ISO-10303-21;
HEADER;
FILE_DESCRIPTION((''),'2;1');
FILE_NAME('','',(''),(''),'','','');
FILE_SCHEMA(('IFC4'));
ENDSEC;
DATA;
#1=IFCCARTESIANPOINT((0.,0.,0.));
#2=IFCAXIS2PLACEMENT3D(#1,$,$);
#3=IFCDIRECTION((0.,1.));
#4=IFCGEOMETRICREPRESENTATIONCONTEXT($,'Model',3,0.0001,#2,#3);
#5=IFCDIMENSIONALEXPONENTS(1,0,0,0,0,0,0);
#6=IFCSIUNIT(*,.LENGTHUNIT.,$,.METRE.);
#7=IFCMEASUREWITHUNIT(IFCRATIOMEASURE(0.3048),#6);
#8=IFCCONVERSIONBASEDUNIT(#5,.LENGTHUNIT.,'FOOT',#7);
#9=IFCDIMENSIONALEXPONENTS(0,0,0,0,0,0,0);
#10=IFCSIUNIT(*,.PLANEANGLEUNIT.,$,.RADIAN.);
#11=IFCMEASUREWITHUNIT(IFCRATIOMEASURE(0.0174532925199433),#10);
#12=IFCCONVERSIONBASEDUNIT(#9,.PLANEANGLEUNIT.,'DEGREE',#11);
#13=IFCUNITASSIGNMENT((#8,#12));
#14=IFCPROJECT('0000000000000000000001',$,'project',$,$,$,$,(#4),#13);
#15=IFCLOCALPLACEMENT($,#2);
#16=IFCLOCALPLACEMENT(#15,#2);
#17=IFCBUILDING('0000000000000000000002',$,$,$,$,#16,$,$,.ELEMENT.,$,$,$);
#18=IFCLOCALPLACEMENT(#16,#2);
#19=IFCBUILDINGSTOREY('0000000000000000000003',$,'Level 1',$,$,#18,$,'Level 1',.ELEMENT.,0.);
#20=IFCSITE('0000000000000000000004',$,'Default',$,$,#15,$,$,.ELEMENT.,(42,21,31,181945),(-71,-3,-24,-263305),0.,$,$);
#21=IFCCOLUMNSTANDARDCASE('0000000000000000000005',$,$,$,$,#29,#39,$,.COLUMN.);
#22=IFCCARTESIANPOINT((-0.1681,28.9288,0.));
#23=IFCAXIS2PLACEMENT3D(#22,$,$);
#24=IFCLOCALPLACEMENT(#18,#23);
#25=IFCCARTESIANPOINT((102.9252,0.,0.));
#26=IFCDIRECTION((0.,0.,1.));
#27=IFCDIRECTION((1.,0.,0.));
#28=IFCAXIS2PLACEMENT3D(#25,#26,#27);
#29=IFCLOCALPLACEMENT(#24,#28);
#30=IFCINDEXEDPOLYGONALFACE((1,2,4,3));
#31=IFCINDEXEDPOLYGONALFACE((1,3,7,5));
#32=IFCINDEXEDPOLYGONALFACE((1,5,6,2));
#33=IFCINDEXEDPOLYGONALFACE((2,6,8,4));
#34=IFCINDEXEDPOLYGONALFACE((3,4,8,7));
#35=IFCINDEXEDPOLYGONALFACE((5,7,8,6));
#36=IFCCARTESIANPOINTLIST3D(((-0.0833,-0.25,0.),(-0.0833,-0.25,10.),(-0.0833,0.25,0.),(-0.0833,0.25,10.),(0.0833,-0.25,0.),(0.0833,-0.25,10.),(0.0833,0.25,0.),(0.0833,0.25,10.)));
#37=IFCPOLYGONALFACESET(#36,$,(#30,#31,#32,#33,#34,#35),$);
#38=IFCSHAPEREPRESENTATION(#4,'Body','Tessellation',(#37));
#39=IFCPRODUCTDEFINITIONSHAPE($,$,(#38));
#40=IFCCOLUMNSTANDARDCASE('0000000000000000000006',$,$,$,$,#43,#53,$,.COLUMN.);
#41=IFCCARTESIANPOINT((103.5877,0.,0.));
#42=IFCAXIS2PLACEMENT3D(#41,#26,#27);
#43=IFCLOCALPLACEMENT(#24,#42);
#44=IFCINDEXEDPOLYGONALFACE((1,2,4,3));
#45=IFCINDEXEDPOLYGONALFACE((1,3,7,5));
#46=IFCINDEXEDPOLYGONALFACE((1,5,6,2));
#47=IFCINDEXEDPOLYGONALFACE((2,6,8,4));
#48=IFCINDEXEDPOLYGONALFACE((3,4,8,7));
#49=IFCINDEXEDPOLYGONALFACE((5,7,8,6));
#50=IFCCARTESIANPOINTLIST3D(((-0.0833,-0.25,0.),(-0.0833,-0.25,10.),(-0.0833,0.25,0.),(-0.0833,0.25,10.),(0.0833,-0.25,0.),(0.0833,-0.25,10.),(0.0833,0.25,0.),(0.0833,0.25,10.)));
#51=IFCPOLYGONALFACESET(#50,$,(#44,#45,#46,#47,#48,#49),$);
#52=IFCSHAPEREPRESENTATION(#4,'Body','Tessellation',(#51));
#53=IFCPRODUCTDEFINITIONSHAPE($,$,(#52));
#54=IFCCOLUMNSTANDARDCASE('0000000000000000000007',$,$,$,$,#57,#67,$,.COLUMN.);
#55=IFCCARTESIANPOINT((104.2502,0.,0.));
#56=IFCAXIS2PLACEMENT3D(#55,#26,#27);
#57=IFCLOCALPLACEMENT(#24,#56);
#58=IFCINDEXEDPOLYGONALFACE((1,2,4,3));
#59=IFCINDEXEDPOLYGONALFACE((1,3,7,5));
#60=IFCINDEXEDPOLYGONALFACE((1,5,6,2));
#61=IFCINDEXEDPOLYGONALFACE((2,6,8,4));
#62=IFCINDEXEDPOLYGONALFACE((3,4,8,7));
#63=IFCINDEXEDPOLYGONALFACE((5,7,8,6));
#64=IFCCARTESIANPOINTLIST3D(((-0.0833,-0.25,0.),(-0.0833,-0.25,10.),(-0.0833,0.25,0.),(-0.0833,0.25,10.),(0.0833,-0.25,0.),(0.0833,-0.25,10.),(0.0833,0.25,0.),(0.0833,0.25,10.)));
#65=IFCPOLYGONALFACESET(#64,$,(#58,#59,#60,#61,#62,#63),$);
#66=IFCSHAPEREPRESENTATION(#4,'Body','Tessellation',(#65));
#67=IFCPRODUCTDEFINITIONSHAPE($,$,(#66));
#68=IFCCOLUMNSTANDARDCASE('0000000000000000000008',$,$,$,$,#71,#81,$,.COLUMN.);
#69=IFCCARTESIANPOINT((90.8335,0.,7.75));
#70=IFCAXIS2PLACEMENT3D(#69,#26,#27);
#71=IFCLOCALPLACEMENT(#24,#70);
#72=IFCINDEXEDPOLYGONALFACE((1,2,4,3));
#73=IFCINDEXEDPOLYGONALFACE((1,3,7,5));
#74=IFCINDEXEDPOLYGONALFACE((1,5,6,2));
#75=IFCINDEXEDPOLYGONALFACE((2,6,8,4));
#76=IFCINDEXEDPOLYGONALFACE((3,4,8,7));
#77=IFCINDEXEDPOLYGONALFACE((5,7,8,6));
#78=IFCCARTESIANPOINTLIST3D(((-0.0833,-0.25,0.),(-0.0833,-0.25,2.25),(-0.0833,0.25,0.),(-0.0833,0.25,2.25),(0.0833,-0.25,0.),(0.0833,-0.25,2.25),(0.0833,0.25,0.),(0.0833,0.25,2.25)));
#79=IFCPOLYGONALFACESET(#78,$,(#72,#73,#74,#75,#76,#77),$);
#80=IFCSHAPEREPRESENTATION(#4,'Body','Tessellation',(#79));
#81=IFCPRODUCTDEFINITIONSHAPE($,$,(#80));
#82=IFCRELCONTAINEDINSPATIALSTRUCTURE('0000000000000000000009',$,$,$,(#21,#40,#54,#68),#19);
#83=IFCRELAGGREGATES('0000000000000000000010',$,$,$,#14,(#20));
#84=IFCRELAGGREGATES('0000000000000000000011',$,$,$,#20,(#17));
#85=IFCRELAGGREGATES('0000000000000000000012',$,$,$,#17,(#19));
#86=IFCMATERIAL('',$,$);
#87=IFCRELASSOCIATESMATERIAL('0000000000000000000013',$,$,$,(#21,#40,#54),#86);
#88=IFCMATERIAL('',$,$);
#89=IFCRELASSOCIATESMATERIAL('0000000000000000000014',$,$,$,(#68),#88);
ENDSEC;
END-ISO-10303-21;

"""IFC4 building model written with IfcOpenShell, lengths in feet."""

from ifc_helpers import new_model, entity, si_unit, converted_unit, direction, frame, origin, place, context, project, spatial, rectangle, extrude, material, element, save


model = new_model("IFC4")

# Units and contexts
model_context = context("Model", 3, precision=0.0001, world=origin(), true_north=direction((0.0, 1.0)))
ifc_project = project(units=[converted_unit("LENGTHUNIT", "FOOT", entity("IfcRatioMeasure", 0.3048), si_unit("LENGTHUNIT", "METRE"), dimensions=[1, 0, 0, 0, 0, 0, 0]), converted_unit("PLANEANGLEUNIT", "DEGREE", entity("IfcRatioMeasure", 0.0174532925199433), si_unit("PLANEANGLEUNIT", "RADIAN"), dimensions=[0, 0, 0, 0, 0, 0, 0])], contexts=[model_context])

# Site, building, storey
site_placement = place(None, origin())
site = spatial("IfcSite", under=ifc_project, at=site_placement, Name="Default", CompositionType="ELEMENT", RefLatitude=(42, 21, 31, 181945), RefLongitude=(-71, -3, -24, -263305), RefElevation=0.0)
building_placement = place(site_placement, origin())
building = spatial("IfcBuilding", under=site, at=building_placement, CompositionType="ELEMENT")
storey_placement = place(building_placement, origin())
storey = spatial("IfcBuildingStorey", under=building, at=storey_placement, Name="Level 1", LongName="Level 1", CompositionType="ELEMENT", Elevation=0.0)

# Columns
ifc_material_1 = material(Name="")
placement_1 = place(storey_placement, frame((-0.1681, 28.9288, 0.0)))
for number, where, z_axis, x_axis in (
    (1, (102.9252, 0.0, 0.0), (0.0, 0.0, 1.0), (1.0, 0.0, 0.0)),
    (2, (103.5877, 0.0, 0.0), (0.0, 0.0, 1.0), (1.0, 0.0, 0.0)),
    (3, (104.2502, 0.0, 0.0), (0.0, 0.0, 1.0), (1.0, 0.0, 0.0)),
):
    element("IfcColumnStandardCase", number, at=place(placement_1, frame(where, z_axis=z_axis, x_axis=x_axis)), inside=storey, material=ifc_material_1, PredefinedType="COLUMN", context=model_context, shape_type="SweptSolid", body=[
        extrude(rectangle(XDim=0.1667, YDim=0.5), origin(), (0.0, 0.0, 1.0), 10.0),
    ])
ifc_material_2 = material(Name="")
for number, where, z_axis, x_axis in (
    (4, (90.8335, 0.0, 7.75), (0.0, 0.0, 1.0), (1.0, 0.0, 0.0)),
):
    element("IfcColumnStandardCase", number, at=place(placement_1, frame(where, z_axis=z_axis, x_axis=x_axis)), inside=storey, material=ifc_material_2, PredefinedType="COLUMN", context=model_context, shape_type="SweptSolid", body=[
        extrude(rectangle(XDim=0.1667, YDim=0.5), origin(), (0.0, 0.0, 1.0), 2.25),
    ])

save(model, "model.ifc")
